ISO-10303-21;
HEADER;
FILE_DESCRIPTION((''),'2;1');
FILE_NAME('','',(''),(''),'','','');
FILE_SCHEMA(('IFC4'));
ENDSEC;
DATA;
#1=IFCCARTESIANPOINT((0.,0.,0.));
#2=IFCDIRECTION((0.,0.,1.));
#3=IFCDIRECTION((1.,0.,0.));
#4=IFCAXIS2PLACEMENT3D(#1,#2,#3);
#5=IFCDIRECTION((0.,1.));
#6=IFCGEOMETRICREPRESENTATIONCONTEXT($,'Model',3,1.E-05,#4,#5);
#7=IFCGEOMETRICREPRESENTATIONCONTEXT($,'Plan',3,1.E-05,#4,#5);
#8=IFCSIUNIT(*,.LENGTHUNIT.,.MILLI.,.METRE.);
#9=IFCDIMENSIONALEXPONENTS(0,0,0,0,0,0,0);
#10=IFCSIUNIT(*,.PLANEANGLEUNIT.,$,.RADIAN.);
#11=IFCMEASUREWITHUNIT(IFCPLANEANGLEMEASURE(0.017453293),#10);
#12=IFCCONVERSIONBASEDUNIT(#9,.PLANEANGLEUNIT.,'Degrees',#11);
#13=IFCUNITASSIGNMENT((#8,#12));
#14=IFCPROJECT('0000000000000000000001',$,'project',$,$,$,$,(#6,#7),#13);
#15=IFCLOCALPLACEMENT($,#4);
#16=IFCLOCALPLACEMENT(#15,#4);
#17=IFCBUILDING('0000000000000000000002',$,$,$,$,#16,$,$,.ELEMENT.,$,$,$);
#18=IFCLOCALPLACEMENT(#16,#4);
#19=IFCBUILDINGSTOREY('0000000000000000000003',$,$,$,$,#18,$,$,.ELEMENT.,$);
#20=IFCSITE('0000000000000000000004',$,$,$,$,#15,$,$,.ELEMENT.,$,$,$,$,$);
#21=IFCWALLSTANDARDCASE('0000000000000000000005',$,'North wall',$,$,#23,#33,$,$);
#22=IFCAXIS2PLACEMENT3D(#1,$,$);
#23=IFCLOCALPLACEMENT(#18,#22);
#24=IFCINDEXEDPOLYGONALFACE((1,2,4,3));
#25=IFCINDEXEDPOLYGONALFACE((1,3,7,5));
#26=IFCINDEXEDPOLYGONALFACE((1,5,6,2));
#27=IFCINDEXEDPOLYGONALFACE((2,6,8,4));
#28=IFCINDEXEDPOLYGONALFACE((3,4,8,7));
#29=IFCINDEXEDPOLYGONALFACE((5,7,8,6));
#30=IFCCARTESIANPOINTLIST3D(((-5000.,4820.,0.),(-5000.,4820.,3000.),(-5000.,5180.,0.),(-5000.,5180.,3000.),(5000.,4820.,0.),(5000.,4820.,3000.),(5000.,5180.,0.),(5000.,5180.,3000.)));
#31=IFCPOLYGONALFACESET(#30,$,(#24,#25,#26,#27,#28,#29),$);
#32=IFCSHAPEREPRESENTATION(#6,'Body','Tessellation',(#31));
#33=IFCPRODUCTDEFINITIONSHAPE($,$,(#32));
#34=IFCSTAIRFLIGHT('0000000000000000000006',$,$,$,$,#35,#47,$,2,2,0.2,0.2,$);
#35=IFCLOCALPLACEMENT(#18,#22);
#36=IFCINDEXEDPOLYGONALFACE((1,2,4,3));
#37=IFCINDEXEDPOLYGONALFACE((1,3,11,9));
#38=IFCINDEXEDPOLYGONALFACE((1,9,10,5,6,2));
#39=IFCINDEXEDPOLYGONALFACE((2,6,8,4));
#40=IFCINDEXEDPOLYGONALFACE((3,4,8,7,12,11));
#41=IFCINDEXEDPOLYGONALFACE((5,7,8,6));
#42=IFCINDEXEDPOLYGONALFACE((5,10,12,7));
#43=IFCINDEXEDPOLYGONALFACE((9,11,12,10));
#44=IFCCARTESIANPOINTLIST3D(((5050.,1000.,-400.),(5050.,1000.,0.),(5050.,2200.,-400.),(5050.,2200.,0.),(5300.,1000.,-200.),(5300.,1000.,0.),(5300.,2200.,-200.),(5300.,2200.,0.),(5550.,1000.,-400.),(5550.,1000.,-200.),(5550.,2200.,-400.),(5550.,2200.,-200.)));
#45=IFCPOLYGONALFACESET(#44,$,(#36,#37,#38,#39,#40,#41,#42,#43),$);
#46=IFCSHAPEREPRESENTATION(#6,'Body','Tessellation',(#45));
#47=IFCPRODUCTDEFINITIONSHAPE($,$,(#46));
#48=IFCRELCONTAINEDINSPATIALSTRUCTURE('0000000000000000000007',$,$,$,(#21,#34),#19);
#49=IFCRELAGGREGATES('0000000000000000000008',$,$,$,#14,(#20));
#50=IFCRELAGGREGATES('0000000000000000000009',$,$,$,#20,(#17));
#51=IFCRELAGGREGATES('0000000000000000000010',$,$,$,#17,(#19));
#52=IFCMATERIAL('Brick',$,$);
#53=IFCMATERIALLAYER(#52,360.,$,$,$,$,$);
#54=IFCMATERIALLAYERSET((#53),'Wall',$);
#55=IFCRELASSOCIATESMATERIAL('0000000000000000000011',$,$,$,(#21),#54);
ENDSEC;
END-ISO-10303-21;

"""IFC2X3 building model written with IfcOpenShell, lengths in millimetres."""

from ifc_helpers import new_model, entity, si_unit, converted_unit, direction, frame, origin_with_axes, place, context, project, spatial, polyline, outline, extrude, material, layer, layer_set, layer_usage, element, save


model = new_model("IFC2X3")

# Units and contexts
model_context = context("Model", 3, precision=1e-05, world=origin_with_axes(), true_north=direction((0.0, 1.0)))
plan_context = context("Plan", 3, precision=1e-05, world=origin_with_axes(), true_north=direction((0.0, 1.0)))
ifc_project = project(units=[si_unit("LENGTHUNIT", "METRE", prefix="MILLI"), converted_unit("PLANEANGLEUNIT", "Degrees", entity("IfcPlaneAngleMeasure", 0.017453293), si_unit("PLANEANGLEUNIT", "RADIAN"), dimensions=[0, 0, 0, 0, 0, 0, 0])], contexts=[model_context, plan_context])

# Site, building, storey
site_placement = place(None, origin_with_axes())
site = spatial("IfcSite", under=ifc_project, at=site_placement, CompositionType="ELEMENT")
building_placement = place(site_placement, origin_with_axes())
building = spatial("IfcBuilding", under=site, at=building_placement, CompositionType="ELEMENT")
storey_placement = place(building_placement, origin_with_axes())
storey = spatial("IfcBuildingStorey", under=building, at=storey_placement, CompositionType="ELEMENT")

# Shared definitions
ifc_material = material(Name="Brick")
ifc_layer = layer(ifc_material, 360.0)
ifc_layer_set = layer_set([ifc_layer], Name="Wall")
ifc_layer_usage = layer_usage(ifc_layer_set, "AXIS2", "POSITIVE", -180.0)

# Wall
wall_1_placement = place(storey_placement, frame((0.0, 5000.0, 0.0), z_axis=(0.0, 0.0, 1.0), x_axis=(1.0, 0.0, 0.0)))
element("IfcWallStandardCase", 1, at=wall_1_placement, inside=storey, material=ifc_layer_usage, Name="North wall", context=model_context, shape_type="SweptSolid", body=[
    extrude(outline(polyline([(-5000.0, -180.0), (5000.0, -180.0), (5000.0, 180.0), (-5000.0, 180.0), (-5000.0, -180.0)])), origin_with_axes(), (0.0, 0.0, 1.0), 3000.0),
])

# Stair flight
stair_flight_placement = place(storey_placement, frame((5050.0, 1000.0, 0.0), z_axis=(0.0, 1.0, 0.0), x_axis=(1.0, 0.0, 0.0)))
element("IfcStairFlight", 2, at=stair_flight_placement, inside=storey, NumberOfRiser=2, NumberOfTreads=2, RiserHeight=0.2, TreadLength=0.2, context=model_context, shape_type="SweptSolid", body=[
    extrude(outline(polyline([(0.0, 0.0), (250.0, 0.0), (250.0, 200.0), (500.0, 200.0), (500.0, 400.0), (0.0, 400.0), (0.0, 0.0)])), origin_with_axes(), (0.0, 0.0, 1.0), 1200.0),
])

save(model, "model.ifc")
